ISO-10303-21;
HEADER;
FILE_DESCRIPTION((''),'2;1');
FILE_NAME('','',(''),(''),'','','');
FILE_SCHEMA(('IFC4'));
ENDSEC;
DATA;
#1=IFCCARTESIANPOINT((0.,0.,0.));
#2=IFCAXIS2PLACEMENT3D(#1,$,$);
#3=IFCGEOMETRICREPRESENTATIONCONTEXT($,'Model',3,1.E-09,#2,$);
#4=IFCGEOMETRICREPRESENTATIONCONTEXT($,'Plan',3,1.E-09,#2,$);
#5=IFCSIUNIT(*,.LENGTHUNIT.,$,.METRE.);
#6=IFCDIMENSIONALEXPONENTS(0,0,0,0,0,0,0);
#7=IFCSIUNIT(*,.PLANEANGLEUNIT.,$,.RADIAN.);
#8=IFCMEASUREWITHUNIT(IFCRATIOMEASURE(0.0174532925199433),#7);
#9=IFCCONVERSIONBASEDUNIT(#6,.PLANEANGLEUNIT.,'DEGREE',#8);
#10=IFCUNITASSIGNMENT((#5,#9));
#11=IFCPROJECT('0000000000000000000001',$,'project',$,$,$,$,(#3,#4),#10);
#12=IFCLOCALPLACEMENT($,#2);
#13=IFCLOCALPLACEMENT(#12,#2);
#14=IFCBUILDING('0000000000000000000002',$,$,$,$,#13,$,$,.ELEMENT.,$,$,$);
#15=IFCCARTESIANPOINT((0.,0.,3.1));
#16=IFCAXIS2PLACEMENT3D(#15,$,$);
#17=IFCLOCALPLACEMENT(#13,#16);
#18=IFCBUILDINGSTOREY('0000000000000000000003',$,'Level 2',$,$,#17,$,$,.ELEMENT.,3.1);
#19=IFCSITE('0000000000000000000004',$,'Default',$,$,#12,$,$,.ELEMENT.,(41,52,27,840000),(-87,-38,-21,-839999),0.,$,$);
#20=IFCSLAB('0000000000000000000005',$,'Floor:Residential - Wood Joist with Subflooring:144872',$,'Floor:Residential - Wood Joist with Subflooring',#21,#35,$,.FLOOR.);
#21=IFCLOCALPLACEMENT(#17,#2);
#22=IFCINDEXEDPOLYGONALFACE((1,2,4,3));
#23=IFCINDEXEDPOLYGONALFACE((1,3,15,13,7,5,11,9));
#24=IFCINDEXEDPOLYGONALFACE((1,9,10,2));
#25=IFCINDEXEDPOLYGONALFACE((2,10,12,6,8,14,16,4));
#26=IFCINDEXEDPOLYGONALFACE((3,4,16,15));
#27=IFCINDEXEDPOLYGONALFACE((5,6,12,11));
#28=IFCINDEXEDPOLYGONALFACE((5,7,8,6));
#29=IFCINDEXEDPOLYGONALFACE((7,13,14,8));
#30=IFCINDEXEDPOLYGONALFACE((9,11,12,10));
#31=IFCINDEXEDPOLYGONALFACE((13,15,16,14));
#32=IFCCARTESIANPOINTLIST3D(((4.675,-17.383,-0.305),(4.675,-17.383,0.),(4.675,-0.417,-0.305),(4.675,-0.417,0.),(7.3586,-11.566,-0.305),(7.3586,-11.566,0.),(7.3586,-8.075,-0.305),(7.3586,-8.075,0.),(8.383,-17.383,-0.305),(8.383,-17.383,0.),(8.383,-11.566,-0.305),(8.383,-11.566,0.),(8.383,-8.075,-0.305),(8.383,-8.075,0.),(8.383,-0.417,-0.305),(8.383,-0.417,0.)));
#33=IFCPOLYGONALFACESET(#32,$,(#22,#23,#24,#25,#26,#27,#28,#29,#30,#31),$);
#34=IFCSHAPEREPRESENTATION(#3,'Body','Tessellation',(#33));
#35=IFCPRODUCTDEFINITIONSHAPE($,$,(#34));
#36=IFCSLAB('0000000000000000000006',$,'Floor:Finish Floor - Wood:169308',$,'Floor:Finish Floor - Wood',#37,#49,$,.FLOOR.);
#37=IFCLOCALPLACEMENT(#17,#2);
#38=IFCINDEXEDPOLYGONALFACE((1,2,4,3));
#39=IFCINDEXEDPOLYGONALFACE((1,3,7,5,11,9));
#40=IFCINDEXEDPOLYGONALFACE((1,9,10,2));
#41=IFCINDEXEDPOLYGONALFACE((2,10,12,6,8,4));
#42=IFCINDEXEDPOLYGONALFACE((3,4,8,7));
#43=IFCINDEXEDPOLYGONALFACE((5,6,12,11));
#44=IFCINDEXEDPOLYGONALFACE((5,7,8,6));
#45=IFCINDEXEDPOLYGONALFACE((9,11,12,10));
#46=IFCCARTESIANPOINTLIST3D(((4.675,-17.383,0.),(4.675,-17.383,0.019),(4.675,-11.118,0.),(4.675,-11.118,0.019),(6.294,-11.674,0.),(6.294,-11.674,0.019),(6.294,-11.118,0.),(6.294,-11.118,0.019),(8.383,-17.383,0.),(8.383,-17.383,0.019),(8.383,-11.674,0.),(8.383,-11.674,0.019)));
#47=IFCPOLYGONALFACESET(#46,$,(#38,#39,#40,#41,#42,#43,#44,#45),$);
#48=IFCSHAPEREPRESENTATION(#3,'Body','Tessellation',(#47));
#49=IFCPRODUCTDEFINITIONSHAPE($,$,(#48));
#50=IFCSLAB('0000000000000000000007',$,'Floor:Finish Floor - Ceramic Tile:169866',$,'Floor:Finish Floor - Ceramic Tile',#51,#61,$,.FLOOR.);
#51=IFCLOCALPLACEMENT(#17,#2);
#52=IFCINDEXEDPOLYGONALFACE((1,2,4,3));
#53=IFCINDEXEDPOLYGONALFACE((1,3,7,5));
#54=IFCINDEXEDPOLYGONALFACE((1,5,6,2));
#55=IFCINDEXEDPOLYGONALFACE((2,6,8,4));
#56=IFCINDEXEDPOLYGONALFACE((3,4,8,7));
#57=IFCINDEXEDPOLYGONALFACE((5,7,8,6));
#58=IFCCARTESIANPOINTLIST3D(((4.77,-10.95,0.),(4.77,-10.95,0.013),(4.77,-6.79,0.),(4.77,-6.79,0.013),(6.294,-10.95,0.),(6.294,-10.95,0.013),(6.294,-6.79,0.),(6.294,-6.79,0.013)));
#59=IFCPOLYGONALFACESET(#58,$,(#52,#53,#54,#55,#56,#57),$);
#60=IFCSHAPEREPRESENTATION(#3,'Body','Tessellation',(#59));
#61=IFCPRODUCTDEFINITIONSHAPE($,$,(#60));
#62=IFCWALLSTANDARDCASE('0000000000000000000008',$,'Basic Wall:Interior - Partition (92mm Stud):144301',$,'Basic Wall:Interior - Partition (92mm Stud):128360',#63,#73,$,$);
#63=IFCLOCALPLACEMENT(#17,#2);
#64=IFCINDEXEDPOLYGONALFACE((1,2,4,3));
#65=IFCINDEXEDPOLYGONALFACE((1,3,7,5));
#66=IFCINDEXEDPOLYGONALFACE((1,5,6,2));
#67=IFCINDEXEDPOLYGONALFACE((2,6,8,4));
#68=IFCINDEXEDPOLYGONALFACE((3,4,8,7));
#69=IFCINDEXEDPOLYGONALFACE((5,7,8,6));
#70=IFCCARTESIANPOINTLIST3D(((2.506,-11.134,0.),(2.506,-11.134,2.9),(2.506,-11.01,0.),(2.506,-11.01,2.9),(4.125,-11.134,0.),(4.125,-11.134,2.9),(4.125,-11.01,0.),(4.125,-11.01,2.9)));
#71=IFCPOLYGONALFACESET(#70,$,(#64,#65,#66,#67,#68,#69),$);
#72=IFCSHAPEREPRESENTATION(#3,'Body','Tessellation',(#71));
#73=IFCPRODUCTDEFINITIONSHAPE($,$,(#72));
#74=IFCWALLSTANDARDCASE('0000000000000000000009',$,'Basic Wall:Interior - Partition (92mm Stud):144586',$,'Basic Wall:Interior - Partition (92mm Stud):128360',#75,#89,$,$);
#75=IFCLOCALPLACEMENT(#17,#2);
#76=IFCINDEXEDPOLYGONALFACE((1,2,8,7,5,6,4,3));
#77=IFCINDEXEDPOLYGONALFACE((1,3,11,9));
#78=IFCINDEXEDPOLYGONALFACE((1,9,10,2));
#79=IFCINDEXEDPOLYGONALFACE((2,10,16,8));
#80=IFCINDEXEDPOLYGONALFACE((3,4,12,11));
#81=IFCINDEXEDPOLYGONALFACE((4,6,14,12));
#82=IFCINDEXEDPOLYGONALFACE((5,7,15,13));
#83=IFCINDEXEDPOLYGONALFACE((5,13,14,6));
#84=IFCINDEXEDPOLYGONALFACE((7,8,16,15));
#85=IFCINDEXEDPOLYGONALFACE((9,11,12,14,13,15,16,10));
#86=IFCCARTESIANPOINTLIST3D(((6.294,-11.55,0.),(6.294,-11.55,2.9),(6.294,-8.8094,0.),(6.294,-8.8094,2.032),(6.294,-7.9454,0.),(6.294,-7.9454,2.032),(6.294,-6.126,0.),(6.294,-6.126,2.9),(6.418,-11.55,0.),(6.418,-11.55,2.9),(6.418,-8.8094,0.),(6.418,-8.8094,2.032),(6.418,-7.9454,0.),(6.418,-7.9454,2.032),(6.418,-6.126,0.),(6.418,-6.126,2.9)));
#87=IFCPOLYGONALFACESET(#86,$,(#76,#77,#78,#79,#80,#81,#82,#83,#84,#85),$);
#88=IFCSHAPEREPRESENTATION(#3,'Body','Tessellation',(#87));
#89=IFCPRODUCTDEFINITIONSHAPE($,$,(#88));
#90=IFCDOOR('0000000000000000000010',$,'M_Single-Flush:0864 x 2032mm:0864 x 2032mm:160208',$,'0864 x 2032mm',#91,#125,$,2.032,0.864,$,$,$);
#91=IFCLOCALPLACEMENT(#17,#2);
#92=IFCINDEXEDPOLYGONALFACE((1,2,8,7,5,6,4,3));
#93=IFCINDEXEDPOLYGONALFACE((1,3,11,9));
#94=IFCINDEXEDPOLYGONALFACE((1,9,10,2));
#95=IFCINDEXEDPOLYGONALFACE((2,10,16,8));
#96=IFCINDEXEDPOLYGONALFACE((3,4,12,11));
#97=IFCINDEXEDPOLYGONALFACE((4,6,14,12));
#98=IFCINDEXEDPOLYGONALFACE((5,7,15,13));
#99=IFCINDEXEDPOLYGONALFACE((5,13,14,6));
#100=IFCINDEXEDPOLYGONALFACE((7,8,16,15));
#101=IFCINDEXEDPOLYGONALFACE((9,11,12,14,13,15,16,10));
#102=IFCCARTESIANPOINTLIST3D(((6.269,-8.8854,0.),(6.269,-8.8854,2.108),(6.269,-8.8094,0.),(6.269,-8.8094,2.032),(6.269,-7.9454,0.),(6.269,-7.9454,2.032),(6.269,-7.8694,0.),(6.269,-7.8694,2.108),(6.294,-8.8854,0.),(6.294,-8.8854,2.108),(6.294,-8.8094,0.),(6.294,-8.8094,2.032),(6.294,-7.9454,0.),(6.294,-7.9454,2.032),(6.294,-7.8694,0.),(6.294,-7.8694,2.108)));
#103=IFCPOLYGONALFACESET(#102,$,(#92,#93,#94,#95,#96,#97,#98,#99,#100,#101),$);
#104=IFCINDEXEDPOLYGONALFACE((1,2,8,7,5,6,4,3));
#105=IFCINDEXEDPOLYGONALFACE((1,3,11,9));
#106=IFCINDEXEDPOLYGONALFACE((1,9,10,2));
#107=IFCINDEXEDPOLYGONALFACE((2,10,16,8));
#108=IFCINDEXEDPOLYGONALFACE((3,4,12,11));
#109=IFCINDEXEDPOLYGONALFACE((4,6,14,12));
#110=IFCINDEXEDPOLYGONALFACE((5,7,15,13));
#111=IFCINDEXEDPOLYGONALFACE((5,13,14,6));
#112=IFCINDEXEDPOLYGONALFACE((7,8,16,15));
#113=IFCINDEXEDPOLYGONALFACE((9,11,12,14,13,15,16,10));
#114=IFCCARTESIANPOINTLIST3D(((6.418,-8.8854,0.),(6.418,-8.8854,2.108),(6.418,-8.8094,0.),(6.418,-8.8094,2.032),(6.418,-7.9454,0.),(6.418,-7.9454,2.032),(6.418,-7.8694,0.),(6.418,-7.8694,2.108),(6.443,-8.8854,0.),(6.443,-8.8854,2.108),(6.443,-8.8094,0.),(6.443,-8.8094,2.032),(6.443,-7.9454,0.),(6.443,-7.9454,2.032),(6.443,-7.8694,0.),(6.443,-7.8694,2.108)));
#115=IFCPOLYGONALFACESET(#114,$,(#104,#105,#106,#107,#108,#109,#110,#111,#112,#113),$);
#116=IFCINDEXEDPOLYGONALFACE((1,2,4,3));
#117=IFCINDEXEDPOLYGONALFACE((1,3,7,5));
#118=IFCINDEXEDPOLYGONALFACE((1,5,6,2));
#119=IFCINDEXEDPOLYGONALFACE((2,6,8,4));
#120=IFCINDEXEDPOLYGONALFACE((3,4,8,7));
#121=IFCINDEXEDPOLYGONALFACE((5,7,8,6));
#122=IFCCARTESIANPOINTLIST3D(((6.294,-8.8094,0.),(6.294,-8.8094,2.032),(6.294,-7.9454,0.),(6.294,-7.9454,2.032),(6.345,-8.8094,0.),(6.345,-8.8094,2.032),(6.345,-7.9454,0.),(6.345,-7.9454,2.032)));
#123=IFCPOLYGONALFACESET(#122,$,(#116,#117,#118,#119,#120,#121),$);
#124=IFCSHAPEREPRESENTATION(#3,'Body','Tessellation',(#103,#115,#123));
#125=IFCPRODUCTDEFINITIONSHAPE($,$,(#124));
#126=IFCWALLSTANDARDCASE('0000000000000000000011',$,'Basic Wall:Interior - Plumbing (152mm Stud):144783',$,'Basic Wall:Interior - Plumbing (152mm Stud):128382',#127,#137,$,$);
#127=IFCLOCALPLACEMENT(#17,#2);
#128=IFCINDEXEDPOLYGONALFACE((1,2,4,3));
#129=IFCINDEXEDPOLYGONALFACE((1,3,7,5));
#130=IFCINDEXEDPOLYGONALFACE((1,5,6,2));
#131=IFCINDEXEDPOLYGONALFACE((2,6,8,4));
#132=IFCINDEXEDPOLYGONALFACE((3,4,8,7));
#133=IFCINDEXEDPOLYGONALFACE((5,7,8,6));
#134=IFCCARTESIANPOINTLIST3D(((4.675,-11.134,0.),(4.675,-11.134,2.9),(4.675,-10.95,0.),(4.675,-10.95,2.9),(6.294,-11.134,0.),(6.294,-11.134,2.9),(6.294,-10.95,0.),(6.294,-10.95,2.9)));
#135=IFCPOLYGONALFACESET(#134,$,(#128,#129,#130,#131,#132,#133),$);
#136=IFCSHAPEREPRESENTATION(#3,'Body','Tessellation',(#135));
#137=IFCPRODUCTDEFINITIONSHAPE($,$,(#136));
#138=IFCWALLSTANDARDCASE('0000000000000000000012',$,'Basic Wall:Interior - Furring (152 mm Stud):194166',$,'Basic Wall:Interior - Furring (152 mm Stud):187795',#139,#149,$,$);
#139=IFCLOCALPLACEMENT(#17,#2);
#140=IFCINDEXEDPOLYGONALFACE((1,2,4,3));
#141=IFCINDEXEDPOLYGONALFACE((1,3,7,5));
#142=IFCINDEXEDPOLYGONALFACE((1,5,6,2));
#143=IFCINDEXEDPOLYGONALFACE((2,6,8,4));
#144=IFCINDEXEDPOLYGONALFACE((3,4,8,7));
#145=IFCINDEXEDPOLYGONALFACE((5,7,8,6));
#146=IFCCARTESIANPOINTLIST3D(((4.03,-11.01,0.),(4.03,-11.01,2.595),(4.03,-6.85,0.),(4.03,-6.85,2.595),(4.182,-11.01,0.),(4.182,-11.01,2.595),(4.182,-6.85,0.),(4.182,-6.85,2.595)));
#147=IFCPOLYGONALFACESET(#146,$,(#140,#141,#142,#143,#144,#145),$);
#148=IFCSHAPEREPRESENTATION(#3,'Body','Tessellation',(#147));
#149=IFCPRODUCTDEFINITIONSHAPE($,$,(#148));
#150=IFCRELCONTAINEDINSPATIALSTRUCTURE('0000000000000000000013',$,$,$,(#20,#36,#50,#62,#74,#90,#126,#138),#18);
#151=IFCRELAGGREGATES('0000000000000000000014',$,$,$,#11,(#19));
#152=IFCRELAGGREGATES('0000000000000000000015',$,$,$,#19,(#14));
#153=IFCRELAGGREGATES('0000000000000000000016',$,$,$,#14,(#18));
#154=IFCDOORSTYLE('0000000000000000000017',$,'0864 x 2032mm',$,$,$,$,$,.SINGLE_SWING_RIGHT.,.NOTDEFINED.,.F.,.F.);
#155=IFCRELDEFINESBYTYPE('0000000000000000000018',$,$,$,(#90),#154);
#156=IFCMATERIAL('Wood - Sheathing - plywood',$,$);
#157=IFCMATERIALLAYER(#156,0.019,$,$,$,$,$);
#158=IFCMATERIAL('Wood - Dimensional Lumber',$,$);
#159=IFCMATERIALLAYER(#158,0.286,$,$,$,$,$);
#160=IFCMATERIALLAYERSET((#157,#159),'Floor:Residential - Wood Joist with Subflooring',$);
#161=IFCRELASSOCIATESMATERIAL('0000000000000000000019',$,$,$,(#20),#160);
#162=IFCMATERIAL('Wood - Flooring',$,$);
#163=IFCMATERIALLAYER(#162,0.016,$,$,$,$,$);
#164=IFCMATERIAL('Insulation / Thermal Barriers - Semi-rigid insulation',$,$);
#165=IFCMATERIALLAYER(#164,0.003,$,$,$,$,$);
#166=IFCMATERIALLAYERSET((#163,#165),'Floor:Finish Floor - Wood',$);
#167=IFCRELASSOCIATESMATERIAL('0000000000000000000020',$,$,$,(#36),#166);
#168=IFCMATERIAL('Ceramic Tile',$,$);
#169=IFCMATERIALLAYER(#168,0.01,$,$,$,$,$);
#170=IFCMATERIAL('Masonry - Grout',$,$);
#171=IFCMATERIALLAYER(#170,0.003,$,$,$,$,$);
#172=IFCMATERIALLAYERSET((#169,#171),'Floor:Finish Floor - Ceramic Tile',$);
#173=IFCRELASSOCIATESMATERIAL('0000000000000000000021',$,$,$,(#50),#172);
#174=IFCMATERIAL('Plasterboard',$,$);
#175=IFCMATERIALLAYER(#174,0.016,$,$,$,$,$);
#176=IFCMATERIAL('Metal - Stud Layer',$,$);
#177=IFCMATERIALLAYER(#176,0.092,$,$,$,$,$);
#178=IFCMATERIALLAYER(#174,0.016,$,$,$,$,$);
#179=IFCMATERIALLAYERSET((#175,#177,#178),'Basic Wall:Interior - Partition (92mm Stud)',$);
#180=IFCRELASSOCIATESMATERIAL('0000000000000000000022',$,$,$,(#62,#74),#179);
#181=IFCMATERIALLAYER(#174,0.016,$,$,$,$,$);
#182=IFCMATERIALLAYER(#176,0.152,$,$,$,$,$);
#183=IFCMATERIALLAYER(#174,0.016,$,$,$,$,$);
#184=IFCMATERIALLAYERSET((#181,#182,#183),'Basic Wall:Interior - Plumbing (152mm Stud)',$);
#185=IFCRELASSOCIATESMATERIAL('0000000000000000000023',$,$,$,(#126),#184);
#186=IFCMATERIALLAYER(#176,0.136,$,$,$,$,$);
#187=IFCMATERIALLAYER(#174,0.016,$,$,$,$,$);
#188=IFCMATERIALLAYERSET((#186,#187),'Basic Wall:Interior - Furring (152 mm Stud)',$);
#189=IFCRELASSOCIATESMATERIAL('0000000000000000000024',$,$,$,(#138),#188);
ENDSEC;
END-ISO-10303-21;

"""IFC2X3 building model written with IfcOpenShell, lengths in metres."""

from ifc_helpers import new_model, entity, si_unit, converted_unit, frame, frame_2d, origin, origin_2d_with_axis, place, context, project, spatial, polyline, rectangle, outline, extrude, source, transform, mapped, material, layer, layer_set, layer_usage, type_object, type_shapes, element, fill, save


model = new_model("IFC2X3")

# Units and contexts
model_context = context("Model", 3, precision=1e-09, world=origin())
plan_context = context("Plan", 3, precision=1e-09, world=origin())
ifc_project = project(units=[si_unit("LENGTHUNIT", "METRE"), converted_unit("PLANEANGLEUNIT", "DEGREE", entity("IfcRatioMeasure", 0.0174532925199433), si_unit("PLANEANGLEUNIT", "RADIAN"), dimensions=[0, 0, 0, 0, 0, 0, 0])], contexts=[model_context, plan_context])

# Site, building, storey
site_placement = place(None, origin())
site = spatial("IfcSite", under=ifc_project, at=site_placement, Name="Default", CompositionType="ELEMENT", RefLatitude=(41, 52, 27, 840000), RefLongitude=(-87, -38, -21, -839999), RefElevation=0.0)
building_placement = place(site_placement, origin())
building = spatial("IfcBuilding", under=site, at=building_placement, CompositionType="ELEMENT")
storey_placement = place(building_placement, frame((0.0, 0.0, 3.1)))
storey = spatial("IfcBuildingStorey", under=building, at=storey_placement, Name="Level 2", CompositionType="ELEMENT", Elevation=3.1)

# Slabs
ifc_material_1 = material(Name="Wood - Sheathing - plywood")
ifc_layer_1 = layer(ifc_material_1, 0.019)
ifc_material_2 = material(Name="Wood - Dimensional Lumber")
ifc_layer_2 = layer(ifc_material_2, 0.286)
ifc_layer_set_1 = layer_set([ifc_layer_1, ifc_layer_2], Name="Floor:Residential - Wood Joist with Subflooring")
ifc_layer_usage_1 = layer_usage(ifc_layer_set_1, "AXIS3", "POSITIVE", 0.0)
slab_1_placement = place(storey_placement, frame((4.675, -17.383, -0.305)))
element("IfcSlab", 1, at=slab_1_placement, inside=storey, material=ifc_layer_usage_1, Name="Floor:Residential - Wood Joist with Subflooring:144872", ObjectType="Floor:Residential - Wood Joist with Subflooring", PredefinedType="FLOOR", context=model_context, shape_type="SweptSolid", body=[
    extrude(outline(polyline([(-1.854, 8.483), (-1.854, 0.825), (-0.8296, 0.825), (-0.8296, -2.666), (-1.854, -2.666), (-1.854, -8.483), (1.854, -8.483), (1.854, 8.483), (-1.854, 8.483)])), frame((1.854, 8.483, 0.305), z_axis=(0.0, 0.0, -1.0), x_axis=(-1.0, 0.0, 0.0)), (0.0, 0.0, 1.0), 0.305),
])
ifc_material_3 = material(Name="Wood - Flooring")
ifc_layer_3 = layer(ifc_material_3, 0.016)
ifc_material_4 = material(Name="Insulation / Thermal Barriers - Semi-rigid insulation")
ifc_layer_4 = layer(ifc_material_4, 0.003)
ifc_layer_set_2 = layer_set([ifc_layer_3, ifc_layer_4], Name="Floor:Finish Floor - Wood")
ifc_layer_usage_2 = layer_usage(ifc_layer_set_2, "AXIS3", "POSITIVE", 0.0)
slab_2_placement = place(storey_placement, frame((4.675, -17.383, 0.0)))
element("IfcSlab", 2, at=slab_2_placement, inside=storey, material=ifc_layer_usage_2, Name="Floor:Finish Floor - Wood:169308", ObjectType="Floor:Finish Floor - Wood", PredefinedType="FLOOR", context=model_context, shape_type="SweptSolid", body=[
    extrude(outline(polyline([(-1.854, 2.5765), (-1.854, -3.1325), (1.854, -3.1325), (1.854, 3.1325), (0.235, 3.1325), (0.235, 2.5765), (-1.854, 2.5765)])), frame((1.854, 3.1325, 0.019), z_axis=(0.0, 0.0, -1.0), x_axis=(-1.0, 0.0, 0.0)), (0.0, 0.0, 1.0), 0.019),
])
ifc_material_5 = material(Name="Ceramic Tile")
ifc_layer_5 = layer(ifc_material_5, 0.01)
ifc_material_6 = material(Name="Masonry - Grout")
ifc_layer_6 = layer(ifc_material_6, 0.003)
ifc_layer_set_3 = layer_set([ifc_layer_5, ifc_layer_6], Name="Floor:Finish Floor - Ceramic Tile")
ifc_layer_usage_3 = layer_usage(ifc_layer_set_3, "AXIS3", "POSITIVE", 0.0)
slab_3_placement = place(storey_placement, frame((4.77, -10.95, 0.0)))
element("IfcSlab", 3, at=slab_3_placement, inside=storey, material=ifc_layer_usage_3, Name="Floor:Finish Floor - Ceramic Tile:169866", ObjectType="Floor:Finish Floor - Ceramic Tile", PredefinedType="FLOOR", context=model_context, shape_type="SweptSolid", body=[
    extrude(rectangle(XDim=4.16, YDim=1.524, at=frame_2d((0.0, 0.0), x_axis=(0.0, -1.0))), frame((0.762, 2.08, 0.013), z_axis=(0.0, 0.0, -1.0), x_axis=(-1.0, 0.0, 0.0)), (0.0, 0.0, 1.0), 0.013),
])

# Shared definitions
ifc_material_7 = material(Name="Metal - Stud Layer")
ifc_material_8 = material(Name="Plasterboard")

# Wall
ifc_layer_7 = layer(ifc_material_8, 0.016)
ifc_layer_8 = layer(ifc_material_7, 0.092)
ifc_layer_9 = layer(ifc_material_8, 0.016)
ifc_layer_set_4 = layer_set([ifc_layer_7, ifc_layer_8, ifc_layer_9], Name="Basic Wall:Interior - Partition (92mm Stud)")
ifc_layer_usage_4 = layer_usage(ifc_layer_set_4, "AXIS2", "NEGATIVE", 0.062)
wall_1_placement = place(storey_placement, frame((4.125, -11.072, 0.0), z_axis=(0.0, 0.0, 1.0), x_axis=(-1.0, 0.0, 0.0)))
element("IfcWallStandardCase", 4, at=wall_1_placement, inside=storey, material=ifc_layer_usage_4, Name="Basic Wall:Interior - Partition (92mm Stud):144301", ObjectType="Basic Wall:Interior - Partition (92mm Stud):128360", context=model_context, shape_type="SweptSolid", body=[
    extrude(rectangle(XDim=1.619, YDim=0.124, at=frame_2d((0.8095, 0.0), x_axis=(-1.0, 0.0))), origin(), (0.0, 0.0, 1.0), 2.9),
])

# Wall, opening, door
ifc_layer_usage_5 = layer_usage(ifc_layer_set_4, "AXIS2", "NEGATIVE", 0.062)
wall_2_placement = place(storey_placement, frame((6.356, -11.55, 0.0), z_axis=(0.0, 0.0, 1.0), x_axis=(0.0, 1.0, 0.0)))
wall_2 = element("IfcWallStandardCase", 5, at=wall_2_placement, inside=storey, material=ifc_layer_usage_5, Name="Basic Wall:Interior - Partition (92mm Stud):144586", ObjectType="Basic Wall:Interior - Partition (92mm Stud):128360", context=model_context, shape_type="SweptSolid", body=[
    extrude(rectangle(XDim=5.424, YDim=0.124, at=frame_2d((2.712, 0.0), x_axis=(-1.0, 0.0))), origin(), (0.0, 0.0, 1.0), 2.9),
])
opening_1_placement = place(wall_2_placement, frame((2.7406, -0.062, 0.0)))
opening_1 = element("IfcOpeningElement", 6, at=opening_1_placement, cuts=wall_2, ObjectType="Opening", context=model_context, shape_type="SweptSolid", body=[
    extrude(rectangle(XDim=0.864, YDim=2.032, at=frame_2d((1.016, 0.432), x_axis=(0.0, 1.0))), frame((0.0, 0.0, 0.0), z_axis=(0.0, 1.0, 0.0), x_axis=(0.0, 0.0, 1.0)), (0.0, 0.0, 1.0), 0.124),
])
door_style = type_object("IfcDoorStyle", Name="0864 x 2032mm", ConstructionType="NOTDEFINED", OperationType="SINGLE_SWING_RIGHT", ParameterTakesPrecedence=False, Sizeable=False)
shared_shape_1 = source(origin(), model_context, "Body", "SweptSolid", [
    extrude(outline(polyline([(-0.508, -1.073), (0.508, -1.073), (0.508, 1.035), (0.432, 1.035), (0.432, -0.997), (-0.432, -0.997), (-0.432, 1.035), (-0.508, 1.035), (-0.508, -1.073)])), frame((0.432, 0.124, 1.035), z_axis=(0.0, 1.0, 0.0), x_axis=(1.0, 0.0, 0.0)), (0.0, 0.0, 1.0), 0.025),
    extrude(outline(polyline([(-1.073, -0.508), (1.035, -0.508), (1.035, -0.432), (-0.997, -0.432), (-0.997, 0.432), (1.035, 0.432), (1.035, 0.508), (-1.073, 0.508), (-1.073, -0.508)])), frame((0.432, -0.025, 1.035), z_axis=(0.0, 1.0, 0.0), x_axis=(0.0, 0.0, -1.0)), (0.0, 0.0, 1.0), 0.025),
    extrude(rectangle(XDim=0.051, YDim=0.864, at=origin_2d_with_axis()), frame((0.432, 0.0985, 0.0), z_axis=(0.0, 0.0, 1.0), x_axis=(0.0, 1.0, 0.0)), (0.0, 0.0, 1.0), 2.032),
])
type_shapes(door_style, [shared_shape_1])
door_placement = place(opening_1_placement, origin())
door = element("IfcDoor", 7, at=door_placement, inside=storey, type_object=door_style, Name="M_Single-Flush:0864 x 2032mm:0864 x 2032mm:160208", ObjectType="0864 x 2032mm", OverallHeight=2.032, OverallWidth=0.864, context=model_context, shape_type="MappedRepresentation", body=[
    mapped(shared_shape_1, transform((0.0, 0.0, 0.0), scale=1.0)),
])
fill(opening_1, door)

# Walls
ifc_layer_10 = layer(ifc_material_8, 0.016)
ifc_layer_11 = layer(ifc_material_7, 0.152)
ifc_layer_12 = layer(ifc_material_8, 0.016)
ifc_layer_set_5 = layer_set([ifc_layer_10, ifc_layer_11, ifc_layer_12], Name="Basic Wall:Interior - Plumbing (152mm Stud)")
ifc_layer_usage_6 = layer_usage(ifc_layer_set_5, "AXIS2", "NEGATIVE", 0.092)
wall_3_placement = place(storey_placement, frame((6.294, -11.042, 0.0), z_axis=(0.0, 0.0, 1.0), x_axis=(-1.0, 0.0, 0.0)))
element("IfcWallStandardCase", 8, at=wall_3_placement, inside=storey, material=ifc_layer_usage_6, Name="Basic Wall:Interior - Plumbing (152mm Stud):144783", ObjectType="Basic Wall:Interior - Plumbing (152mm Stud):128382", context=model_context, shape_type="SweptSolid", body=[
    extrude(rectangle(XDim=1.619, YDim=0.184, at=frame_2d((0.8095, 0.0), x_axis=(-1.0, 0.0))), origin(), (0.0, 0.0, 1.0), 2.9),
])
ifc_layer_13 = layer(ifc_material_7, 0.136)
ifc_layer_14 = layer(ifc_material_8, 0.016)
ifc_layer_set_6 = layer_set([ifc_layer_13, ifc_layer_14], Name="Basic Wall:Interior - Furring (152 mm Stud)")
ifc_layer_usage_7 = layer_usage(ifc_layer_set_6, "AXIS2", "POSITIVE", -0.076)
wall_4_placement = place(storey_placement, frame((4.106, -11.01, 0.0), z_axis=(0.0, 0.0, 1.0), x_axis=(0.0, 1.0, 0.0)))
element("IfcWallStandardCase", 9, at=wall_4_placement, inside=storey, material=ifc_layer_usage_7, Name="Basic Wall:Interior - Furring (152 mm Stud):194166", ObjectType="Basic Wall:Interior - Furring (152 mm Stud):187795", context=model_context, shape_type="SweptSolid", body=[
    extrude(rectangle(XDim=4.16, YDim=0.152, at=frame_2d((2.08, 0.0), x_axis=(-1.0, 0.0))), origin(), (0.0, 0.0, 1.0), 2.595),
])

save(model, "model.ifc")
